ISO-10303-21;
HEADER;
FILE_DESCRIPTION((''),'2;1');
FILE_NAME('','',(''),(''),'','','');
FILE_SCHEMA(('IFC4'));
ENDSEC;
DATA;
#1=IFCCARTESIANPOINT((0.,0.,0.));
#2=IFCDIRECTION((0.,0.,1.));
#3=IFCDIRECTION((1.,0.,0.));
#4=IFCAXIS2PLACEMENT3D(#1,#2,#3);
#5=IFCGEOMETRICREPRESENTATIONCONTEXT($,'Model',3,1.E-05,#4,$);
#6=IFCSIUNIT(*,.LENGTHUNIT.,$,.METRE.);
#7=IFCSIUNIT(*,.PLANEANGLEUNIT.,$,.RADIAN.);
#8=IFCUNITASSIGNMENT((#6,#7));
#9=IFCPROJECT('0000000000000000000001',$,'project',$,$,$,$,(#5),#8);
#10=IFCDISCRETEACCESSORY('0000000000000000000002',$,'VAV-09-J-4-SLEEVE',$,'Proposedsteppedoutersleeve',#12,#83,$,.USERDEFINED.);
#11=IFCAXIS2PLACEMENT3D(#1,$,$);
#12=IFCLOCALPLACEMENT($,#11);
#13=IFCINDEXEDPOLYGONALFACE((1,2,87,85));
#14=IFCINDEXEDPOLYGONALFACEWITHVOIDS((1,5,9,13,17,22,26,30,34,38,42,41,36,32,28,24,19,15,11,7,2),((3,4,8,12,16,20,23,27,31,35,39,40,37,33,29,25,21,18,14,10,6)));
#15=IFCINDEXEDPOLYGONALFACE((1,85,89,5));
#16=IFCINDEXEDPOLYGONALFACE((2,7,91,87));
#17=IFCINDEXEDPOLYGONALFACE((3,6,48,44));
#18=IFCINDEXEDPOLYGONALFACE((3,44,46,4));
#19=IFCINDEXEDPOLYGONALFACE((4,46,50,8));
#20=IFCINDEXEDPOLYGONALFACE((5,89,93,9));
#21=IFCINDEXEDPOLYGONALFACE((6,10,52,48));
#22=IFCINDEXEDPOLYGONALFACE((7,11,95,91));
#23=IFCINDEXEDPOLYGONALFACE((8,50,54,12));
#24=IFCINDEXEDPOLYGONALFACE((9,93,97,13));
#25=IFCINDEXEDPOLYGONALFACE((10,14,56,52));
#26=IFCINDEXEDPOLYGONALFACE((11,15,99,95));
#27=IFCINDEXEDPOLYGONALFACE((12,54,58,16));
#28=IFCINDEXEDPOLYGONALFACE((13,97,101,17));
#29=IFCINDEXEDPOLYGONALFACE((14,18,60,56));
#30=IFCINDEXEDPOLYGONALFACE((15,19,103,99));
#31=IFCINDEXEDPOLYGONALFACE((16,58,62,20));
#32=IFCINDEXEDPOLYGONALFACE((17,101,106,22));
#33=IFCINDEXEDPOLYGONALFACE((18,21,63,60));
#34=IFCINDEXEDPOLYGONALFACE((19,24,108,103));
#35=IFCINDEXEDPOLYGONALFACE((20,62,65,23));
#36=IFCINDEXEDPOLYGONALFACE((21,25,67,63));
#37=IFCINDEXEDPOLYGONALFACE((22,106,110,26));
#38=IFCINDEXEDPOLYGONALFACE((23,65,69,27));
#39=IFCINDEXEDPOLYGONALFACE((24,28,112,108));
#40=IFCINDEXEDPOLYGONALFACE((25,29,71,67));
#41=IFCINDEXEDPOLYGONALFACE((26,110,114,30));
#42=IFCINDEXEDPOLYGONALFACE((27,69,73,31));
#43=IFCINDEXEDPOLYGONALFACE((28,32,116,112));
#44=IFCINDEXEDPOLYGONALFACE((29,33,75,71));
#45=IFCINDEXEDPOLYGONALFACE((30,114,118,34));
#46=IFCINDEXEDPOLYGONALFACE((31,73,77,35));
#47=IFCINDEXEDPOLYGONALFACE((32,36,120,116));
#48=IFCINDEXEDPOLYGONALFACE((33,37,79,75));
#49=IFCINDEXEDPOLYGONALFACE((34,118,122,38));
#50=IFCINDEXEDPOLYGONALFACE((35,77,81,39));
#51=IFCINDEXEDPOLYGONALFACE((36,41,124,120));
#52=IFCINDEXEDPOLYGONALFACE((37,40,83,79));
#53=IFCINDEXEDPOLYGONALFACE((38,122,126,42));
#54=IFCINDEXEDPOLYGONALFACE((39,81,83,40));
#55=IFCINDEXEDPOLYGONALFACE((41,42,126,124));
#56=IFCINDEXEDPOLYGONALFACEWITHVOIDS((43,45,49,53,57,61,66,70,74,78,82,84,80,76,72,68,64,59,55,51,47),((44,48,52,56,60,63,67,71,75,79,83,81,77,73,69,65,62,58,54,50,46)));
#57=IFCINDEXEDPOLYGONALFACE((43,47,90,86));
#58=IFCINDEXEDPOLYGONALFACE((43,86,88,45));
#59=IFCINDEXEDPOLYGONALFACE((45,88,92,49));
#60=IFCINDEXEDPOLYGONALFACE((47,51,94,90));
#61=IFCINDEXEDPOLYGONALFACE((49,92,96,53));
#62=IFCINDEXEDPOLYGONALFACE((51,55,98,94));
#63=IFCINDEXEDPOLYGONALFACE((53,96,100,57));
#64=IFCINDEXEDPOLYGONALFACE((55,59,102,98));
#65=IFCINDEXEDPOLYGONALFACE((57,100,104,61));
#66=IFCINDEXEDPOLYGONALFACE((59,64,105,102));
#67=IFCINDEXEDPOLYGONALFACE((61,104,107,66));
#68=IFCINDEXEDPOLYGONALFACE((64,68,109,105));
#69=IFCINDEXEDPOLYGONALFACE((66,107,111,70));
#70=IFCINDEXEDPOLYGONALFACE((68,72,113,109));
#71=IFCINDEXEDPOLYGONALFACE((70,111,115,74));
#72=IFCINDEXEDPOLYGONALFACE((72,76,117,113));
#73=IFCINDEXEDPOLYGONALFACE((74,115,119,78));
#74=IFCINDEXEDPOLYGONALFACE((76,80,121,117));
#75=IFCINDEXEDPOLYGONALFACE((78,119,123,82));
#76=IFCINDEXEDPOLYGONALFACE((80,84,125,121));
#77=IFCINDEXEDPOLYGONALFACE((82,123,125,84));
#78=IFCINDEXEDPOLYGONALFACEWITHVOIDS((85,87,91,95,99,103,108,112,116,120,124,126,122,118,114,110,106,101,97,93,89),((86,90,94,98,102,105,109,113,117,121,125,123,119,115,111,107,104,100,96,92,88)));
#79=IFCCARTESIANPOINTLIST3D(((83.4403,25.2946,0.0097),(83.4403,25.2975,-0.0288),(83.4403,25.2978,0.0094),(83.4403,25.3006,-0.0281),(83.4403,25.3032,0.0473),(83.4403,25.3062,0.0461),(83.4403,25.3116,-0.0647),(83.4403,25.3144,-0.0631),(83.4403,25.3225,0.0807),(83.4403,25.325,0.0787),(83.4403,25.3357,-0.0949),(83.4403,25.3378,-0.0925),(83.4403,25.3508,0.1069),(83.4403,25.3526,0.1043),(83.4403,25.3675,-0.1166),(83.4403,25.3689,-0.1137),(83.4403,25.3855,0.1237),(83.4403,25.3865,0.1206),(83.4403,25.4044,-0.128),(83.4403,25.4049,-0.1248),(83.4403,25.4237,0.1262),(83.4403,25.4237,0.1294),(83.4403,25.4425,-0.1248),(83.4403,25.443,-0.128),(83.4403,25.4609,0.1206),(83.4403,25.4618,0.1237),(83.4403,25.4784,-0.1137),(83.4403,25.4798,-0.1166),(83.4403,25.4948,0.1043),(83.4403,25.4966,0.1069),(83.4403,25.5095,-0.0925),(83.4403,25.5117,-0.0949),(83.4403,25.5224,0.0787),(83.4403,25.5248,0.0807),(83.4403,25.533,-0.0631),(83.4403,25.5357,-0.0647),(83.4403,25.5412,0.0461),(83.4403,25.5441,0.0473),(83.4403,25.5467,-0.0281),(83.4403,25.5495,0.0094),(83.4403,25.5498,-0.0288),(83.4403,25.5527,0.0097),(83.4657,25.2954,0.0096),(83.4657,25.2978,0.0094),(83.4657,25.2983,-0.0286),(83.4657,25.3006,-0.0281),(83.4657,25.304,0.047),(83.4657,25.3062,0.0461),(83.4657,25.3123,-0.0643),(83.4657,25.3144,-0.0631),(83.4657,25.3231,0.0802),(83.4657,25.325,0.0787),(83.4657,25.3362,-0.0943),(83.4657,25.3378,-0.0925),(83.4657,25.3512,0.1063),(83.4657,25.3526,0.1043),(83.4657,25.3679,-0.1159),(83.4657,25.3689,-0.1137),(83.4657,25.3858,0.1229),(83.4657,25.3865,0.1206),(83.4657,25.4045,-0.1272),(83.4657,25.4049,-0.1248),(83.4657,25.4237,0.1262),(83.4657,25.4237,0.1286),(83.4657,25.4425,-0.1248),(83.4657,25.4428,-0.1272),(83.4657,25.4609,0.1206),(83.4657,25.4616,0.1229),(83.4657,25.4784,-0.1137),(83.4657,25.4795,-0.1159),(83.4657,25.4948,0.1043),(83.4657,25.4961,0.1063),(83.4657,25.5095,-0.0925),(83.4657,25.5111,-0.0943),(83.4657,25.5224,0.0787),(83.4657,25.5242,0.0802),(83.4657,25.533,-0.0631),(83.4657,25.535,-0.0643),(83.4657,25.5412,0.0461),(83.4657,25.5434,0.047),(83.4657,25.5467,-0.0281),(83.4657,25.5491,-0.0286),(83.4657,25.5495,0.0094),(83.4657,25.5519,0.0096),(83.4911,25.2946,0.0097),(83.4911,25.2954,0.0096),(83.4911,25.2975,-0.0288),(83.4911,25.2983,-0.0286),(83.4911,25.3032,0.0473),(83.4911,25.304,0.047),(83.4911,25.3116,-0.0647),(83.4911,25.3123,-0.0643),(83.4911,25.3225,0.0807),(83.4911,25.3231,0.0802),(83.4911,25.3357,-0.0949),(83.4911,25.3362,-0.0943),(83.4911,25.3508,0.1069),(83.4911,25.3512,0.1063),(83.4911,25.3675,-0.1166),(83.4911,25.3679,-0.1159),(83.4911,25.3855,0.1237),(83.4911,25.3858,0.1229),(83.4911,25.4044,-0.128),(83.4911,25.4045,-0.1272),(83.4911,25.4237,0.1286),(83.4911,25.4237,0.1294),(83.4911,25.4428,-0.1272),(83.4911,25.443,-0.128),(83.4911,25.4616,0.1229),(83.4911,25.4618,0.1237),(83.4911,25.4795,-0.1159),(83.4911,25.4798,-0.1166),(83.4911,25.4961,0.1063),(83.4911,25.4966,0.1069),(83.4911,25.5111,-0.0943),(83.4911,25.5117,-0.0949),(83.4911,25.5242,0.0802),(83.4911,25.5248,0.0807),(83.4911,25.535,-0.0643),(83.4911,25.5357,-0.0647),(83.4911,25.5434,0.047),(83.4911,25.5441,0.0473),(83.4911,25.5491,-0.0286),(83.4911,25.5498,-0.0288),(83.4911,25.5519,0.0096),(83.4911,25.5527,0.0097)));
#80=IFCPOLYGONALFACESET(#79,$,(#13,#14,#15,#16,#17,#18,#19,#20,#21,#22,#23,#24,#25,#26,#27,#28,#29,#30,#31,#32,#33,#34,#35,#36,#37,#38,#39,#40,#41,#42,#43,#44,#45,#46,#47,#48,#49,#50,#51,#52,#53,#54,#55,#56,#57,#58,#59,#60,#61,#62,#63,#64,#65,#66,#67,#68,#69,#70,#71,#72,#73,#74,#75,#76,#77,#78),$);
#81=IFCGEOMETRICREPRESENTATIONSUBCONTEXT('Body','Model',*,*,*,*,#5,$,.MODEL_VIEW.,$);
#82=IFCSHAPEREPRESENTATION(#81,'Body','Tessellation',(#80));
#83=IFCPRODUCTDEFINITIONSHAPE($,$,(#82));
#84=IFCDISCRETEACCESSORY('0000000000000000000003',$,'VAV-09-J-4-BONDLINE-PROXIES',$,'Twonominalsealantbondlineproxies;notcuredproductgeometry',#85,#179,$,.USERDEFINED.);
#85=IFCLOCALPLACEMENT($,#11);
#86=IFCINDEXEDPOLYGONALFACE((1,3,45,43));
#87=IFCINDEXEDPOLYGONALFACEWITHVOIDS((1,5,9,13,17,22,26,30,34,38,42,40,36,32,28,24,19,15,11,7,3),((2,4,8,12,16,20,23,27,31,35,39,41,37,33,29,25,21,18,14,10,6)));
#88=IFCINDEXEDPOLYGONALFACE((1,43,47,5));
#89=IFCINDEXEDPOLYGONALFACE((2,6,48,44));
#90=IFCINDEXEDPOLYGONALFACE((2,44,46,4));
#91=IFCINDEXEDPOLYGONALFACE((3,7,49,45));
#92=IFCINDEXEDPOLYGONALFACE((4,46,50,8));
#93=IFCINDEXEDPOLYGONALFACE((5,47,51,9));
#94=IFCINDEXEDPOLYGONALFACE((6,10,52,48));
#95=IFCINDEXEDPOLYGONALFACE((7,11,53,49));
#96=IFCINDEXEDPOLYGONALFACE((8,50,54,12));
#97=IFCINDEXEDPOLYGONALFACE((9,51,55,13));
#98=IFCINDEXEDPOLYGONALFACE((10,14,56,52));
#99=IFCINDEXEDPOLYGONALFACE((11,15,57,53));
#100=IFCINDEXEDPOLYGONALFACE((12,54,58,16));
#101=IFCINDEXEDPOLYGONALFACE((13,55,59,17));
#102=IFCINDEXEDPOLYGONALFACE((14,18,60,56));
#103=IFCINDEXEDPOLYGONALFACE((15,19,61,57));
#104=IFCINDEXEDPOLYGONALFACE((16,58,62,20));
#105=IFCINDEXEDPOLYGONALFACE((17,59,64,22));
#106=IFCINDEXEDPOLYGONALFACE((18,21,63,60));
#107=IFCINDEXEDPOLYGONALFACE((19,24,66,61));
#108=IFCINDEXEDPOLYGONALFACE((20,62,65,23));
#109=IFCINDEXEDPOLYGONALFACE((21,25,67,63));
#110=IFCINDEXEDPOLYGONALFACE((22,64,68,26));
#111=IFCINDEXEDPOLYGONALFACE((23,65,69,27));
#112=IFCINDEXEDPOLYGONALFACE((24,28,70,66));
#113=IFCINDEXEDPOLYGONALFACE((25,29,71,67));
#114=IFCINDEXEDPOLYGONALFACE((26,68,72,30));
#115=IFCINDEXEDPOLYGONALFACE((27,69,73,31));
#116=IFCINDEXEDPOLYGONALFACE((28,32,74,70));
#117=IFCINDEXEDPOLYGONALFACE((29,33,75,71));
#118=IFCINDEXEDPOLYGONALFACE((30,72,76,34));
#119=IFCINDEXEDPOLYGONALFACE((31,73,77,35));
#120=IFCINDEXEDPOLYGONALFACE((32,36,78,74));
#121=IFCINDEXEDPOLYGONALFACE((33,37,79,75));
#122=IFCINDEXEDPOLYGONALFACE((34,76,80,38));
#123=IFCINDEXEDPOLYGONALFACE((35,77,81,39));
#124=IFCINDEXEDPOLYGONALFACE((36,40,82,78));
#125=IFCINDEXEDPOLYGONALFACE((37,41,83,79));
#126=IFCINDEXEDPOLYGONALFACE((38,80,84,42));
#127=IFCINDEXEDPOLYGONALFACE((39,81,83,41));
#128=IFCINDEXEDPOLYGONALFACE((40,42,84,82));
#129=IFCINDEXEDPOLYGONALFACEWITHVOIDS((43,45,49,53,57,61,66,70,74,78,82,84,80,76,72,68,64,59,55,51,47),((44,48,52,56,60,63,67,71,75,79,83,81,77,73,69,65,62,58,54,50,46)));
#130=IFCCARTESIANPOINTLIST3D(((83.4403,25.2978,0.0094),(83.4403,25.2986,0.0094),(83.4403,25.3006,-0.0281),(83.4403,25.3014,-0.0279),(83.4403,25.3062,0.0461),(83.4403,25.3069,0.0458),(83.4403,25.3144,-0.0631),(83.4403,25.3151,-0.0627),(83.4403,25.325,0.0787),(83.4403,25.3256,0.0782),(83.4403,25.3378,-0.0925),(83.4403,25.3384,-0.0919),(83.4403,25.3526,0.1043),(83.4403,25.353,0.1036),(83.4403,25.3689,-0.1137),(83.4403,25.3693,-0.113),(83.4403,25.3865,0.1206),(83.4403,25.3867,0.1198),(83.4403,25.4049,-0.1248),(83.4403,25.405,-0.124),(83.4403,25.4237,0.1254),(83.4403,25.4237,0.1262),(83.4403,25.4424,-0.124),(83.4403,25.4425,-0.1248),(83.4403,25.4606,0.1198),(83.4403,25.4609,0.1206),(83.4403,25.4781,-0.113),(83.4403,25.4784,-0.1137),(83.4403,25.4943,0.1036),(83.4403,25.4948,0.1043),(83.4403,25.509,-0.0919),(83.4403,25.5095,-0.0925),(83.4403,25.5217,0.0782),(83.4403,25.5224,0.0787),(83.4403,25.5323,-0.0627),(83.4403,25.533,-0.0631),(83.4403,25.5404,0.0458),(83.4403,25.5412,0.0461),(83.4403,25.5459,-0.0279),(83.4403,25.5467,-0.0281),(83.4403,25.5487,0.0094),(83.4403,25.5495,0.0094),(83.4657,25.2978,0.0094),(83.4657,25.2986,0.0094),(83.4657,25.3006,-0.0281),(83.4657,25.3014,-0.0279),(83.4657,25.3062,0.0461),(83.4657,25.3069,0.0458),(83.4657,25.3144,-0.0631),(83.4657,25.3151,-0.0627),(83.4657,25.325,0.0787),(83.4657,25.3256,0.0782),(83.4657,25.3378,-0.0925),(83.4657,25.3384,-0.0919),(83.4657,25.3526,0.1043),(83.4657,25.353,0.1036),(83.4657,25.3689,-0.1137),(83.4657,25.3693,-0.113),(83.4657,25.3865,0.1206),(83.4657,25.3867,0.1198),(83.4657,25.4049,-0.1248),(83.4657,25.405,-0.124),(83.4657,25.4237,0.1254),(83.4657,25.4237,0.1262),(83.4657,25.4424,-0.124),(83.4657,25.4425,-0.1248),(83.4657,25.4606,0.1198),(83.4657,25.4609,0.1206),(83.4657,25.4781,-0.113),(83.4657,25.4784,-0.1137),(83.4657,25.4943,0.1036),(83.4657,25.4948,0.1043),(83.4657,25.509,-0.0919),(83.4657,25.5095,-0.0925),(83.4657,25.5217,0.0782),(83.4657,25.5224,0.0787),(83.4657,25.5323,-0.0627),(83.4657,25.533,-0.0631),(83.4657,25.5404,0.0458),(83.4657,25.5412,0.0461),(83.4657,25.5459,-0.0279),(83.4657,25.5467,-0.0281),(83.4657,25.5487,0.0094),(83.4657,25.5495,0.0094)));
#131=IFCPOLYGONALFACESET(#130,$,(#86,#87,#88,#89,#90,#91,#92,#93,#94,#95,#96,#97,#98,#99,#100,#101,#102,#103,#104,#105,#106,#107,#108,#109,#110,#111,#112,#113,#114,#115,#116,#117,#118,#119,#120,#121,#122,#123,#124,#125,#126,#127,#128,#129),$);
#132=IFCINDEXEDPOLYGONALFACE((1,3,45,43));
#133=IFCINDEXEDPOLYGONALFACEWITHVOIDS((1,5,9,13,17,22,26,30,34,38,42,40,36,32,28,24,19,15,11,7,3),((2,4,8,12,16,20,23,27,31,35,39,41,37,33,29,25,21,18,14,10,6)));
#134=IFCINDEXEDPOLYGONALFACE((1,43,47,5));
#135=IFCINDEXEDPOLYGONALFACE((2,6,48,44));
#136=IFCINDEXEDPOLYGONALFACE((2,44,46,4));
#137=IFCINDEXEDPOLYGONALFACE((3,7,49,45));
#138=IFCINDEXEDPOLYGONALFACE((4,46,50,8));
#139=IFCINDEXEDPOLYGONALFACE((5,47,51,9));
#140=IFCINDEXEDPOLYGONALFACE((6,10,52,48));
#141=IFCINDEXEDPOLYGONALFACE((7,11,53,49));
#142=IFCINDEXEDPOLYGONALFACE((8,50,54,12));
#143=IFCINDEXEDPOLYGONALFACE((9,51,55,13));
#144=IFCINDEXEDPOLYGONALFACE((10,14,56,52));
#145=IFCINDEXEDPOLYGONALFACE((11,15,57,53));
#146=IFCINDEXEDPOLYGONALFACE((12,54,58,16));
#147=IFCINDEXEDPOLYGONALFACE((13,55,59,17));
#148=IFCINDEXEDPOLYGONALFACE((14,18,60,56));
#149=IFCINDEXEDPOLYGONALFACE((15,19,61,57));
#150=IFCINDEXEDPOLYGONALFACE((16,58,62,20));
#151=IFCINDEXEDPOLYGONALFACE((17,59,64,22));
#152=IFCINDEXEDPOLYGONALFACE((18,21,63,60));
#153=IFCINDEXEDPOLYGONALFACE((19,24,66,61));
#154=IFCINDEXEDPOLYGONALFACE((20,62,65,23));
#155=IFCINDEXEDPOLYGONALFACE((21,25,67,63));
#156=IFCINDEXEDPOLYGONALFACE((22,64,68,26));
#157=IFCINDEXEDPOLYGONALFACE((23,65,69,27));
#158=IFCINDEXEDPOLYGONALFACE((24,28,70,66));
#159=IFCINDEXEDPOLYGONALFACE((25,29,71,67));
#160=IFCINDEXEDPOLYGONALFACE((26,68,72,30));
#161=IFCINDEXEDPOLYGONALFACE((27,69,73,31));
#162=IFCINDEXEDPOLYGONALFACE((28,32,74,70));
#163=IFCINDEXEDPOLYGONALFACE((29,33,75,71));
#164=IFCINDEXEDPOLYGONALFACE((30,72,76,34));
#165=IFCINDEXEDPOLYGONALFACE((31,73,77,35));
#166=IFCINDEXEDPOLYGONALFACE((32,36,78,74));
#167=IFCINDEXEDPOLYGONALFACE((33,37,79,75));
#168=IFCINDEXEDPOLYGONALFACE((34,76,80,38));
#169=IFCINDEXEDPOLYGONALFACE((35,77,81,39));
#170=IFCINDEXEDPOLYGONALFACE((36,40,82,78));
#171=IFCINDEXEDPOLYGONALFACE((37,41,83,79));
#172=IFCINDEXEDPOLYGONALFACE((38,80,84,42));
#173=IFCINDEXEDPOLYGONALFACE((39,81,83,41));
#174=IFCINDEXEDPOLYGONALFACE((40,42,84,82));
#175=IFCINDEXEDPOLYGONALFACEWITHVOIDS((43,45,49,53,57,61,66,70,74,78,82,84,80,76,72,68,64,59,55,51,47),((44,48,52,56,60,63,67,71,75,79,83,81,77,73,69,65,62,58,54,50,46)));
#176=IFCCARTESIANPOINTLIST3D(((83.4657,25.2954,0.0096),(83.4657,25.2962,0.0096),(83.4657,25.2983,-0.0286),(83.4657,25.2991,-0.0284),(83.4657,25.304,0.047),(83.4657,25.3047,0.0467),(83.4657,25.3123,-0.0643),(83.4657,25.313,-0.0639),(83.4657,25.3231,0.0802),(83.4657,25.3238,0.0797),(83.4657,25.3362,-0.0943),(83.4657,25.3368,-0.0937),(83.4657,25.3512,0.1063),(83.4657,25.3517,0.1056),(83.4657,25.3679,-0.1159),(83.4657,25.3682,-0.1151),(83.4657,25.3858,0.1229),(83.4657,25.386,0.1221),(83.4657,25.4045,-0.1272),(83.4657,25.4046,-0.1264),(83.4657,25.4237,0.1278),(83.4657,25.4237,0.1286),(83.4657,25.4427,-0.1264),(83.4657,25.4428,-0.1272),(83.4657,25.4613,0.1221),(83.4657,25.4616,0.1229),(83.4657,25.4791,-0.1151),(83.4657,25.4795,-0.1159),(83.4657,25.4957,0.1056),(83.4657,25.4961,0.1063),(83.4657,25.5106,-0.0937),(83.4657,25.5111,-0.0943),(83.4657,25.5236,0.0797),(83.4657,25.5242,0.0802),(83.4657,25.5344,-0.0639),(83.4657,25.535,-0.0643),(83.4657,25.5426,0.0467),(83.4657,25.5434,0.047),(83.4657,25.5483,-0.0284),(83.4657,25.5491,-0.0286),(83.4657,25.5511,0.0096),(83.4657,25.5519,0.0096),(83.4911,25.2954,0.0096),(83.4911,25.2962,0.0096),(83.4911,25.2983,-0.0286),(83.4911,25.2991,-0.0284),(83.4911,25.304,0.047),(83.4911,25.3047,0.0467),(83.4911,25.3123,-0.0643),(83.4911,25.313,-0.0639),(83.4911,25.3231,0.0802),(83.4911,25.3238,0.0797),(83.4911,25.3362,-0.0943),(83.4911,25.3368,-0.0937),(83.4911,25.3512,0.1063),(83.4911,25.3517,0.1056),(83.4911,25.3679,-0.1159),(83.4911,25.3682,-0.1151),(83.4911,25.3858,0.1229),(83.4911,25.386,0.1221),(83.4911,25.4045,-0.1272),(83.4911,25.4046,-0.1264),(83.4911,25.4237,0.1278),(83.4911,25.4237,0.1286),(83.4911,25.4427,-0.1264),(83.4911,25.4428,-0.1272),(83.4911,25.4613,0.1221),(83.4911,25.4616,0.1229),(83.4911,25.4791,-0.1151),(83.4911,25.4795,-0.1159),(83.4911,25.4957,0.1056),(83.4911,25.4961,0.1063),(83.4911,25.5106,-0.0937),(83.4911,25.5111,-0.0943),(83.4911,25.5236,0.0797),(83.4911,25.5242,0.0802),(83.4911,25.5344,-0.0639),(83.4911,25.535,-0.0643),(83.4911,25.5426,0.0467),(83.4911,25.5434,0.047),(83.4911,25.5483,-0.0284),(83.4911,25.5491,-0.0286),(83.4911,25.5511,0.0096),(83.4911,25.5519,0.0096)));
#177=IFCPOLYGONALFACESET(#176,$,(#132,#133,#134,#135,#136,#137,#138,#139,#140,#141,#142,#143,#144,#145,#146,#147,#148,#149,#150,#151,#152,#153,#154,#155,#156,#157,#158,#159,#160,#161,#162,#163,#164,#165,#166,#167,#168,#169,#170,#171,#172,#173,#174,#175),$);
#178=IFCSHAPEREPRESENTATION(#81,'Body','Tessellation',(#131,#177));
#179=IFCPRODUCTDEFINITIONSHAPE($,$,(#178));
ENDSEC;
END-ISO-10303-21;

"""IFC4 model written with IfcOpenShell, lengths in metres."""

from ifc_helpers import new_model, entity, si_unit, frame, origin_with_axes, place, context, subcontext, project, element, save


model = new_model("IFC4")

# Units and contexts
model_context = context("Model", 3, precision=1e-05, world=origin_with_axes())
body_context = subcontext(model_context, "Body", "Model", "MODEL_VIEW")
ifc_project = project(units=[si_unit("LENGTHUNIT", "METRE"), si_unit("PLANEANGLEUNIT", "RADIAN")], contexts=[model_context])

# Discrete accessories
discrete_accessory_1_placement = place(None, frame((83.4657, 25.4237, 0.0), z_axis=(0.0, 1.0, 0.0), x_axis=(0.0, 0.0, 1.0)))
element("IfcDiscreteAccessory", 1, at=discrete_accessory_1_placement, Name="VAV-09-J-4-SLEEVE", ObjectType="Proposedsteppedoutersleeve", PredefinedType="USERDEFINED", context=body_context, shape_type="SweptSolid", body=[
    entity("IfcRevolvedAreaSolid", entity("IfcArbitraryClosedProfileDef", "AREA", None, entity("IfcPolyline", [entity("IfcCartesianPoint", [0.1262, -0.0254]), entity("IfcCartesianPoint", [0.1294, -0.0254]), entity("IfcCartesianPoint", [0.1294, 0.0254]), entity("IfcCartesianPoint", [0.1286, 0.0254]), entity("IfcCartesianPoint", [0.1286, 0.0]), entity("IfcCartesianPoint", [0.1262, 0.0]), entity("IfcCartesianPoint", [0.1262, -0.0254])])), entity("IfcAxis2Placement3D", entity("IfcCartesianPoint", [0.0, 0.0, 0.0])), entity("IfcAxis1Placement", entity("IfcCartesianPoint", [0.0, 0.0, 0.0]), entity("IfcDirection", [0.0, 1.0, 0.0])), 6.283185),
])
discrete_accessory_2_placement = place(None, frame((83.4657, 25.4237, 0.0), z_axis=(0.0, 1.0, 0.0), x_axis=(0.0, 0.0, 1.0)))
element("IfcDiscreteAccessory", 2, at=discrete_accessory_2_placement, Name="VAV-09-J-4-BONDLINE-PROXIES", ObjectType="Twonominalsealantbondlineproxies;notcuredproductgeometry", PredefinedType="USERDEFINED", context=body_context, shape_type="SweptSolid", body=[
    entity("IfcRevolvedAreaSolid", entity("IfcArbitraryClosedProfileDef", "AREA", None, entity("IfcPolyline", [entity("IfcCartesianPoint", [0.1254, -0.0254]), entity("IfcCartesianPoint", [0.1262, -0.0254]), entity("IfcCartesianPoint", [0.1262, 0.0]), entity("IfcCartesianPoint", [0.1254, 0.0]), entity("IfcCartesianPoint", [0.1254, -0.0254])])), entity("IfcAxis2Placement3D", entity("IfcCartesianPoint", [0.0, 0.0, 0.0])), entity("IfcAxis1Placement", entity("IfcCartesianPoint", [0.0, 0.0, 0.0]), entity("IfcDirection", [0.0, 1.0, 0.0])), 6.283185),
    entity("IfcRevolvedAreaSolid", entity("IfcArbitraryClosedProfileDef", "AREA", None, entity("IfcPolyline", [entity("IfcCartesianPoint", [0.1278, 0.0]), entity("IfcCartesianPoint", [0.1286, 0.0]), entity("IfcCartesianPoint", [0.1286, 0.0254]), entity("IfcCartesianPoint", [0.1278, 0.0254]), entity("IfcCartesianPoint", [0.1278, 0.0])])), entity("IfcAxis2Placement3D", entity("IfcCartesianPoint", [0.0, 0.0, 0.0])), entity("IfcAxis1Placement", entity("IfcCartesianPoint", [0.0, 0.0, 0.0]), entity("IfcDirection", [0.0, 1.0, 0.0])), 6.283185),
])

save(model, "model.ifc")
